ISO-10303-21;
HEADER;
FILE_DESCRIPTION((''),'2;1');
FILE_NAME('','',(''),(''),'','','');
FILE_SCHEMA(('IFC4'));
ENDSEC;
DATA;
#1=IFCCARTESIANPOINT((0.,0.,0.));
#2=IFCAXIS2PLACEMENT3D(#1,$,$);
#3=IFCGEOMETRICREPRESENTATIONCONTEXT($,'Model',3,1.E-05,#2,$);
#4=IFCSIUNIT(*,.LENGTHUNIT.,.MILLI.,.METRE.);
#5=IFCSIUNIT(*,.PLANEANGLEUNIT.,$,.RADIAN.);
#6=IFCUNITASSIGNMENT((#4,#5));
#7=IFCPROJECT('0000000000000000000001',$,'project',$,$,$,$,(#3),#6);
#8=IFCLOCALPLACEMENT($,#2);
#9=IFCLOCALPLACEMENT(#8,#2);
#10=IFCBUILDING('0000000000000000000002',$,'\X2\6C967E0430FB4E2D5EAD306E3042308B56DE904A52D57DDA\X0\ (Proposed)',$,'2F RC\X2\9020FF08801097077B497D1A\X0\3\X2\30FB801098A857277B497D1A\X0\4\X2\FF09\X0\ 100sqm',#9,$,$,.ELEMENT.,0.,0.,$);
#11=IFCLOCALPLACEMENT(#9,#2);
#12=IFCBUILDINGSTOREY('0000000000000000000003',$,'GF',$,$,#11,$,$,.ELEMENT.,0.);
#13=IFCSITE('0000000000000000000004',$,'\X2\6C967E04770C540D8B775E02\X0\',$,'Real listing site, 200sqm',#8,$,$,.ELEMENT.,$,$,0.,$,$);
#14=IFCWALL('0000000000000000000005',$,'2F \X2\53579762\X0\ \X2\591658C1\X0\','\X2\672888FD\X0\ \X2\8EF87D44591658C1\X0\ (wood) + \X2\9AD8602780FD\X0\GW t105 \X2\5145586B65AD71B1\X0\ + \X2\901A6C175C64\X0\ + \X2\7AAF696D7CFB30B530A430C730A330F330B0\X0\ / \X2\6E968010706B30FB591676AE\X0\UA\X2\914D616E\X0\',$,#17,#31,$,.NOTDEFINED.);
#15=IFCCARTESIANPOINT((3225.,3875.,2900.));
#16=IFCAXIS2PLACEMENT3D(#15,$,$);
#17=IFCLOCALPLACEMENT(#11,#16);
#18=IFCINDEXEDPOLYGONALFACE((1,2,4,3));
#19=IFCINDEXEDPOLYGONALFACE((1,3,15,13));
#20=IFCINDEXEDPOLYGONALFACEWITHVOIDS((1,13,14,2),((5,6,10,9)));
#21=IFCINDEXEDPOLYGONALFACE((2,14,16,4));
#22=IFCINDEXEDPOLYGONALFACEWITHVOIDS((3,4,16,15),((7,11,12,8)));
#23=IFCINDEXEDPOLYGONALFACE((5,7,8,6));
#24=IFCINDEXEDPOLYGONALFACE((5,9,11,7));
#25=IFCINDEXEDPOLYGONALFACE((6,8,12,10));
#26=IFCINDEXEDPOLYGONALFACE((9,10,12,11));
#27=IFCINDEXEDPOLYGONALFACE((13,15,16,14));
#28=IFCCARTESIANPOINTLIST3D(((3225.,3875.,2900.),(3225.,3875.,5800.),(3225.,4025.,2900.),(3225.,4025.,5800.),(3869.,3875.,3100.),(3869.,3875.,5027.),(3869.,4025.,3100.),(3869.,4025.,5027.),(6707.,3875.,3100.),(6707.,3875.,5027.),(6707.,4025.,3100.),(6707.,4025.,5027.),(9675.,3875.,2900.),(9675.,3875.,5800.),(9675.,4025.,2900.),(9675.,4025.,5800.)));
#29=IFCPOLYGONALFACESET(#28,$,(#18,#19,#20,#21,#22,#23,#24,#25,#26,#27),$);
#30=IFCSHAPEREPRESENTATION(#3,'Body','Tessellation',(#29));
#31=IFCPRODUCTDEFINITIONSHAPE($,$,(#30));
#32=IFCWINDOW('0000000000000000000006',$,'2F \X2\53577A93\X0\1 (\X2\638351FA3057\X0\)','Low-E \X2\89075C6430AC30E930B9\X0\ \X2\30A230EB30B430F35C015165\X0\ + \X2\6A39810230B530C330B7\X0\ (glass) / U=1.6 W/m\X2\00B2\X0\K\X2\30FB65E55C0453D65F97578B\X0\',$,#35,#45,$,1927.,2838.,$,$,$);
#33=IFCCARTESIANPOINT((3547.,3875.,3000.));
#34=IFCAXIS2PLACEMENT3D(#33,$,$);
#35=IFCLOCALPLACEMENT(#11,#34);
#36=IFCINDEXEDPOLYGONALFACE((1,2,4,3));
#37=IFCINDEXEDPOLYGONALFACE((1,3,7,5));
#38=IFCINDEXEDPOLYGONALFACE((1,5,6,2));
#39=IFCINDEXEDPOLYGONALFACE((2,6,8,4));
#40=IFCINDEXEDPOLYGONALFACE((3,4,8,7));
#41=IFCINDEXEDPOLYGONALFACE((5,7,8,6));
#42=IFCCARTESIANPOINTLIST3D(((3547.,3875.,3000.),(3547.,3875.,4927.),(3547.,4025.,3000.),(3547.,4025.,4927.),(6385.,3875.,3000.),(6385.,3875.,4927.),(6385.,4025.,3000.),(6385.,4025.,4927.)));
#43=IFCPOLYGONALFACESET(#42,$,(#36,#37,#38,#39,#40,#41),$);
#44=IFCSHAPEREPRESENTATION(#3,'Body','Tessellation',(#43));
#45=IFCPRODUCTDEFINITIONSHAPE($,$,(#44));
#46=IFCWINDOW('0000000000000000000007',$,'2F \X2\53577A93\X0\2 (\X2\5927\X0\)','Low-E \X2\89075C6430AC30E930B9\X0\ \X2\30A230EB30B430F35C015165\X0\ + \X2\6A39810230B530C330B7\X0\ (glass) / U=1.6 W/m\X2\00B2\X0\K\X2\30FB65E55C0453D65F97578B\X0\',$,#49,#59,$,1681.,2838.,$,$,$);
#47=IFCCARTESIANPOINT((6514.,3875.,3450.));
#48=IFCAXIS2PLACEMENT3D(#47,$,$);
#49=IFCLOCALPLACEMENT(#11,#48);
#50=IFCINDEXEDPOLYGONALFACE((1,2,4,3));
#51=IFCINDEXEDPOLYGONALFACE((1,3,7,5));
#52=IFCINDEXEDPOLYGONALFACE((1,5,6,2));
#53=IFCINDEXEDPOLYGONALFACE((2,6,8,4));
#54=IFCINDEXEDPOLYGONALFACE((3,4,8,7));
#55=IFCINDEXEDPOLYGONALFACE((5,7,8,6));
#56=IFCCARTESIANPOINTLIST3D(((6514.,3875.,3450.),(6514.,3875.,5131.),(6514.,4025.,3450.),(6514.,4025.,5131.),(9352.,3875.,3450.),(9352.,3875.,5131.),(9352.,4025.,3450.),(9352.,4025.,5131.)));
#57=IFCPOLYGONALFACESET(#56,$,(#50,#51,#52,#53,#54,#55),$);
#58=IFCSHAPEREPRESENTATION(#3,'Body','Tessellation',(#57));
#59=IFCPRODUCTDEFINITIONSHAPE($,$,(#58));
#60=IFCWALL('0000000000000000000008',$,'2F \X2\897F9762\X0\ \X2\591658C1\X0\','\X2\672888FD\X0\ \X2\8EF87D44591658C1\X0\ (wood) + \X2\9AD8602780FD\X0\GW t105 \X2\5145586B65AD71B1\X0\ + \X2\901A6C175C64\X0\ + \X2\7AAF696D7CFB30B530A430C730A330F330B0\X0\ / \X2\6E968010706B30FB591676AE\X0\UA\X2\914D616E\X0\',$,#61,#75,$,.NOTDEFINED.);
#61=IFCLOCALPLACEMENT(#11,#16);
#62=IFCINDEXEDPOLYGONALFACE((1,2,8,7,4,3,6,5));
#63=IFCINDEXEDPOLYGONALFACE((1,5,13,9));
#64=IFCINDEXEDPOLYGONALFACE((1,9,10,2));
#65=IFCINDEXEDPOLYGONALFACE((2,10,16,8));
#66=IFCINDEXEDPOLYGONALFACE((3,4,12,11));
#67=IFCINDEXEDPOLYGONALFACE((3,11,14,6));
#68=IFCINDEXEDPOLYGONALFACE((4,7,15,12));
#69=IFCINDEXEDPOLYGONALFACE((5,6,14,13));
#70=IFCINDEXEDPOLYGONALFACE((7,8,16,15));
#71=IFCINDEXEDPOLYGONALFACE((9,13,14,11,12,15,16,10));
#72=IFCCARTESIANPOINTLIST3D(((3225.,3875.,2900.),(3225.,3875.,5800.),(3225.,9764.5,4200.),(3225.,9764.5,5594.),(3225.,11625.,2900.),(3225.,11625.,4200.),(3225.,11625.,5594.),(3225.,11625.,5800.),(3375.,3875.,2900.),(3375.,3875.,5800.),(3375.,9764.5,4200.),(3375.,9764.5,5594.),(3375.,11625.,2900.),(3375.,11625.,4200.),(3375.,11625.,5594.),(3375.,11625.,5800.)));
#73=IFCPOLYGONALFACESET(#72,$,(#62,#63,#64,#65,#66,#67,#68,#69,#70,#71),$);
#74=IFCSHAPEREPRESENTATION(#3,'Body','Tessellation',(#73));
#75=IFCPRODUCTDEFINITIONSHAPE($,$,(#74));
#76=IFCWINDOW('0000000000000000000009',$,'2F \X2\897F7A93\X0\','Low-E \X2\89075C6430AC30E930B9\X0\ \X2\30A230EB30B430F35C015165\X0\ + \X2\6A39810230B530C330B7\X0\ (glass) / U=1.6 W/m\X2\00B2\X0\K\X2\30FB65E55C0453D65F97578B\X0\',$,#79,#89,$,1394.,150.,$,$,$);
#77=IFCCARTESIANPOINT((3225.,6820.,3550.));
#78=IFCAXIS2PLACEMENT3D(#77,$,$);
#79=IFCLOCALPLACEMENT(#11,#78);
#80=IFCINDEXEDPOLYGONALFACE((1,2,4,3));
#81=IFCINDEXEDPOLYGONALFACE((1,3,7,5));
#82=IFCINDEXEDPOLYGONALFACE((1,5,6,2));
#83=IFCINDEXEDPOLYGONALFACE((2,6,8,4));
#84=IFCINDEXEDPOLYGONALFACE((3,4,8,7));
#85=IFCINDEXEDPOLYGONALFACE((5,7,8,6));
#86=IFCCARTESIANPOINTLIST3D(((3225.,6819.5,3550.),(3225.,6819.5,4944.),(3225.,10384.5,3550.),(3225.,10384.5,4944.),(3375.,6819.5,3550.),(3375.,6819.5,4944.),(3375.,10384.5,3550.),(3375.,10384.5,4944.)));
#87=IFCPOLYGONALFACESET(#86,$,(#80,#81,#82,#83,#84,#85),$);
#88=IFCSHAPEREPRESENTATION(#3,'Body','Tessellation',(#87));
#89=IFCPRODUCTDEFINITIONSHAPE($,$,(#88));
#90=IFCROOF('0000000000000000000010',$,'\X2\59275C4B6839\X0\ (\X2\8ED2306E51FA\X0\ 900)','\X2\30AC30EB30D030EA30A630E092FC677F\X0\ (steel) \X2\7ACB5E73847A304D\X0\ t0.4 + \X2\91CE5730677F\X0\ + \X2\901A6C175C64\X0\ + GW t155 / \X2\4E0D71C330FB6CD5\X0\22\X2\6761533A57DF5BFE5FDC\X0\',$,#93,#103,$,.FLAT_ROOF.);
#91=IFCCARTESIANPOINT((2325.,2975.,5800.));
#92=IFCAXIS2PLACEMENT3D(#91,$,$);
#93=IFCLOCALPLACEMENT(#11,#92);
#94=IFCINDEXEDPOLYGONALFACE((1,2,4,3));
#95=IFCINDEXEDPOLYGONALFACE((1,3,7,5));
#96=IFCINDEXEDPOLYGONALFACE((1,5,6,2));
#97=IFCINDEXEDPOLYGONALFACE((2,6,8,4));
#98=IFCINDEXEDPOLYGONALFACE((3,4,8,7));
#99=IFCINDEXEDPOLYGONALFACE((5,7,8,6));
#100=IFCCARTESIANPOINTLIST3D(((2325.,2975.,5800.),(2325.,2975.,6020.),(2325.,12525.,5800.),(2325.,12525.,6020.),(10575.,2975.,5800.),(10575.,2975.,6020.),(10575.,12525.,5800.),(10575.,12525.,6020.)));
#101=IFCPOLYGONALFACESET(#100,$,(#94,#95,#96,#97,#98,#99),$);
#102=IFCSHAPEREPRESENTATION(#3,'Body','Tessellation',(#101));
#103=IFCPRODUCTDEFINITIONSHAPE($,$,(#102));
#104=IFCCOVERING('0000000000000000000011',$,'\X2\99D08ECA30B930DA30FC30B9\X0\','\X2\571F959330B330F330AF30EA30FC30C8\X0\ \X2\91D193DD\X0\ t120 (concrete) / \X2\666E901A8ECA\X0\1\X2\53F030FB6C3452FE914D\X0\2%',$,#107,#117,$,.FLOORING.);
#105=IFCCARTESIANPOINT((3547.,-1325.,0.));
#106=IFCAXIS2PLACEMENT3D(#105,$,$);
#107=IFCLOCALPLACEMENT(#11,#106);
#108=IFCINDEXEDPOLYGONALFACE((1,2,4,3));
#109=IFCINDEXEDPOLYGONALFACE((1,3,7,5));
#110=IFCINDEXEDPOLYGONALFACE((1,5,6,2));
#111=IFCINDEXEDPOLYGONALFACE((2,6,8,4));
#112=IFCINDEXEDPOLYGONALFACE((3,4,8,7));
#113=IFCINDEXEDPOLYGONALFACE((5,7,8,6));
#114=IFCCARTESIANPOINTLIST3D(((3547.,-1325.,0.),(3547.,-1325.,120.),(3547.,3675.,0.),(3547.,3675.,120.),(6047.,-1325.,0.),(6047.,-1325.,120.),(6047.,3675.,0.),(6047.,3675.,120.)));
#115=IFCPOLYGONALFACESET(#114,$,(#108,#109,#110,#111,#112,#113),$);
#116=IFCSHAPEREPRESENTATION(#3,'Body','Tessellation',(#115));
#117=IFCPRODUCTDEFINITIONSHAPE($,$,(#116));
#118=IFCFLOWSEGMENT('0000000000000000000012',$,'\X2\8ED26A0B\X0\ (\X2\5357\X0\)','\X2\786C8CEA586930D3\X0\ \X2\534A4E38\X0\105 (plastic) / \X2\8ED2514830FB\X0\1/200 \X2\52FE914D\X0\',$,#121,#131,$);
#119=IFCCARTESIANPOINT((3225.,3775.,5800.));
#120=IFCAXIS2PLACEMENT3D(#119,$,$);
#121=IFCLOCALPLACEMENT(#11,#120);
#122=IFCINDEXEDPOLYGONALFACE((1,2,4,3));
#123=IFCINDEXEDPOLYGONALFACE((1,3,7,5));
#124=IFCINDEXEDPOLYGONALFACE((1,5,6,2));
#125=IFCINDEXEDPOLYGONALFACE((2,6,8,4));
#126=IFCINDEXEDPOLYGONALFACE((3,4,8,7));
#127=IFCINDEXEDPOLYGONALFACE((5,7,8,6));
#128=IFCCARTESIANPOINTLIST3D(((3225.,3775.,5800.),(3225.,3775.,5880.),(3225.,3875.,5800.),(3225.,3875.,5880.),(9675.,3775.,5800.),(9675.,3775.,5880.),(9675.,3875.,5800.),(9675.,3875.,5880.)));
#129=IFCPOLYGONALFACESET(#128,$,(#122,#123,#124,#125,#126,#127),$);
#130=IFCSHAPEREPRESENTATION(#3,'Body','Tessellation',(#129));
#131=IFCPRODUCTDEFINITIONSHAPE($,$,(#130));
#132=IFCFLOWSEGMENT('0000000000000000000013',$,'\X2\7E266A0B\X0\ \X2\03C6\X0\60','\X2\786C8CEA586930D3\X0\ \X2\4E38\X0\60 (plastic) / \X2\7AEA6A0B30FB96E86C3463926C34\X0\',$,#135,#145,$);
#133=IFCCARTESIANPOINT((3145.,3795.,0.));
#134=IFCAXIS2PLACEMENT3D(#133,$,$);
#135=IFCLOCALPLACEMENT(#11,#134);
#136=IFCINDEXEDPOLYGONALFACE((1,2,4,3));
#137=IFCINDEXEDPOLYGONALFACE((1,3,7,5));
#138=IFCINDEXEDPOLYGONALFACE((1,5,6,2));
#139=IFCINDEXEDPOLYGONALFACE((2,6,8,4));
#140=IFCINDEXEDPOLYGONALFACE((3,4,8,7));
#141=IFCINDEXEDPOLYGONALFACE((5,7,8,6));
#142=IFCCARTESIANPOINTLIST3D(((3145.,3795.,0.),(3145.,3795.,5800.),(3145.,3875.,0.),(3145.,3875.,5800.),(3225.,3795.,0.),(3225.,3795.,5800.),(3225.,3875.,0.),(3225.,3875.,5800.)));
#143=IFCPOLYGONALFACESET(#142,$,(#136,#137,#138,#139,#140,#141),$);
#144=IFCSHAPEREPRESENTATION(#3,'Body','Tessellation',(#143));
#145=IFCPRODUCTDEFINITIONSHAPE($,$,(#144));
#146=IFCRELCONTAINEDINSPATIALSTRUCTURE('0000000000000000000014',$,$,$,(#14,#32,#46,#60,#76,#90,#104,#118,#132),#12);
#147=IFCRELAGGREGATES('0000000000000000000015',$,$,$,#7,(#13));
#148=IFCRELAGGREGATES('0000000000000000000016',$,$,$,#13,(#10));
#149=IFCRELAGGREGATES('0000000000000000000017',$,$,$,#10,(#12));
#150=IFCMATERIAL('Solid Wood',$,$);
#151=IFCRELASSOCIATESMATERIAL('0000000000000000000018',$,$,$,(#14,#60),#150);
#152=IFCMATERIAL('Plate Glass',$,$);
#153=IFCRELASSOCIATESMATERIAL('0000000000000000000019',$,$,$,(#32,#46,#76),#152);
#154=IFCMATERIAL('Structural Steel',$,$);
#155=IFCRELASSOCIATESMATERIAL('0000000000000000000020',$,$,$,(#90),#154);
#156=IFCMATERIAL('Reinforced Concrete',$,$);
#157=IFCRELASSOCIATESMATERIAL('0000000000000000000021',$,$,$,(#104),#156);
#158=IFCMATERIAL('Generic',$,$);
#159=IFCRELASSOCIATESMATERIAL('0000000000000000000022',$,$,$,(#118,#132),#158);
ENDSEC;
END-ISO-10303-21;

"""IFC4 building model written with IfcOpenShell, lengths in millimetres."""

from ifc_helpers import new_model, si_unit, frame, frame_2d, origin, place, context, project, spatial, rectangle, extrude, material, element, fill, save


model = new_model("IFC4")

# Units and contexts
model_context = context("Model", 3, precision=1e-05, world=origin())
ifc_project = project(units=[si_unit("LENGTHUNIT", "METRE", prefix="MILLI"), si_unit("PLANEANGLEUNIT", "RADIAN")], contexts=[model_context])

# Site, building, storey
site_placement = place(None, origin())
site = spatial("IfcSite", under=ifc_project, at=site_placement, Name="沖縄県名護市", ObjectType="Real listing site, 200sqm", CompositionType="ELEMENT", RefElevation=0.0)
building_placement = place(site_placement, origin())
building = spatial("IfcBuilding", under=site, at=building_placement, Name="沖縄・中庭のある回遊動線 (Proposed)", ObjectType="2F RC造（耐震等級3・耐風圧等級4） 100sqm", CompositionType="ELEMENT", ElevationOfRefHeight=0.0, ElevationOfTerrain=0.0)
storey_placement = place(building_placement, origin())
storey = spatial("IfcBuildingStorey", under=building, at=storey_placement, Name="GF", CompositionType="ELEMENT", Elevation=0.0)

# Shared definitions
ifc_material_1 = material(Name="Solid Wood")

# Shared definitions
ifc_material_2 = material(Name="Reinforced Concrete")

# Shared definitions
ifc_material_3 = material(Name="Plate Glass")

# Wall, openings, windows
wall_1_placement = place(storey_placement, frame((3225.0, 3875.0, 2900.0)))
wall_1 = element("IfcWall", 1, at=wall_1_placement, inside=storey, material=ifc_material_1, Name="2F 南面 外壁", Description="木製 軸組外壁 (wood) + 高性能GW t105 充填断熱 + 通気層 + 窯業系サイディング / 準耐火・外皮UA配慮", PredefinedType="NOTDEFINED", context=model_context, shape_type="SweptSolid", body=[
    extrude(rectangle(XDim=6450.0, YDim=150.0, at=frame_2d((3225.0, 75.0))), frame((3225.0, 3875.0, 2900.0)), (0.0, 0.0, 1.0), 2900.0),
])
opening_1_placement = place(storey_placement, frame((3547.0, 3875.0, 3000.0)))
opening_1 = element("IfcOpeningElement", 2, at=opening_1_placement, cuts=wall_1, PredefinedType="NOTDEFINED", context=model_context, shape_type="SweptSolid", body=[
    extrude(rectangle(XDim=2838.0, YDim=150.0, at=frame_2d((1419.0, 75.0))), frame((3547.0, 3875.0, 3000.0)), (0.0, 0.0, 1.0), 1927.0),
])
opening_2_placement = place(storey_placement, frame((6514.0, 3875.0, 3450.0)))
opening_2 = element("IfcOpeningElement", 3, at=opening_2_placement, cuts=wall_1, PredefinedType="NOTDEFINED", context=model_context, shape_type="SweptSolid", body=[
    extrude(rectangle(XDim=2838.0, YDim=150.0, at=frame_2d((1419.0, 75.0))), frame((6514.0, 3875.0, 3450.0)), (0.0, 0.0, 1.0), 1681.0),
])
window_1_placement = place(storey_placement, frame((3547.0, 3875.0, 3000.0)))
window_1 = element("IfcWindow", 4, at=window_1_placement, inside=storey, material=ifc_material_3, Name="2F 南窓1 (掃出し)", Description="Low-E 複層ガラス アルゴン封入 + 樹脂サッシ (glass) / U=1.6 W/m²K・日射取得型", OverallHeight=1927.0, OverallWidth=2838.0, context=model_context, shape_type="SweptSolid", body=[
    extrude(rectangle(XDim=2838.0, YDim=150.0, at=frame_2d((1419.0, 75.0))), frame((3547.0, 3875.0, 3000.0)), (0.0, 0.0, 1.0), 1927.0),
])
fill(opening_1, window_1)
window_2_placement = place(storey_placement, frame((6514.0, 3875.0, 3450.0)))
window_2 = element("IfcWindow", 5, at=window_2_placement, inside=storey, material=ifc_material_3, Name="2F 南窓2 (大)", Description="Low-E 複層ガラス アルゴン封入 + 樹脂サッシ (glass) / U=1.6 W/m²K・日射取得型", OverallHeight=1681.0, OverallWidth=2838.0, context=model_context, shape_type="SweptSolid", body=[
    extrude(rectangle(XDim=2838.0, YDim=150.0, at=frame_2d((1419.0, 75.0))), frame((6514.0, 3875.0, 3450.0)), (0.0, 0.0, 1.0), 1681.0),
])
fill(opening_2, window_2)

# Wall, opening, window
wall_2_placement = place(storey_placement, frame((3225.0, 3875.0, 2900.0)))
wall_2 = element("IfcWall", 6, at=wall_2_placement, inside=storey, material=ifc_material_1, Name="2F 西面 外壁", Description="木製 軸組外壁 (wood) + 高性能GW t105 充填断熱 + 通気層 + 窯業系サイディング / 準耐火・外皮UA配慮", PredefinedType="NOTDEFINED", context=model_context, shape_type="SweptSolid", body=[
    extrude(rectangle(XDim=150.0, YDim=7750.0, at=frame_2d((75.0, 3875.0))), frame((3225.0, 3875.0, 2900.0)), (0.0, 0.0, 1.0), 2900.0),
])
opening_3_placement = place(storey_placement, frame((3225.0, 6820.0, 3550.0)))
opening_3 = element("IfcOpeningElement", 7, at=opening_3_placement, cuts=wall_2, PredefinedType="NOTDEFINED", context=model_context, shape_type="SweptSolid", body=[
    extrude(rectangle(XDim=150.0, YDim=3565.0, at=frame_2d((75.0, 1782.0))), frame((3225.0, 6820.0, 3550.0)), (0.0, 0.0, 1.0), 1394.0),
])
window_3_placement = place(storey_placement, frame((3225.0, 6820.0, 3550.0)))
window_3 = element("IfcWindow", 8, at=window_3_placement, inside=storey, material=ifc_material_3, Name="2F 西窓", Description="Low-E 複層ガラス アルゴン封入 + 樹脂サッシ (glass) / U=1.6 W/m²K・日射取得型", OverallHeight=1394.0, OverallWidth=150.0, context=model_context, shape_type="SweptSolid", body=[
    extrude(rectangle(XDim=150.0, YDim=3565.0, at=frame_2d((75.0, 1782.0))), frame((3225.0, 6820.0, 3550.0)), (0.0, 0.0, 1.0), 1394.0),
])
fill(opening_3, window_3)

# Roof
ifc_material_4 = material(Name="Structural Steel")
roof_placement = place(storey_placement, frame((2325.0, 2975.0, 5800.0)))
element("IfcRoof", 9, at=roof_placement, inside=storey, material=ifc_material_4, Name="大屋根 (軒の出 900)", Description="ガルバリウム鋼板 (steel) 立平葺き t0.4 + 野地板 + 通気層 + GW t155 / 不燃・法22条区域対応", PredefinedType="FLAT_ROOF", context=model_context, shape_type="SweptSolid", body=[
    extrude(rectangle(XDim=8250.0, YDim=9550.0, at=frame_2d((4125.0, 4775.0))), frame((2325.0, 2975.0, 5800.0)), (0.0, 0.0, 1.0), 220.0),
])

# Covering
covering_placement = place(storey_placement, frame((3547.0, -1325.0, 0.0)))
element("IfcCovering", 10, at=covering_placement, inside=storey, material=ifc_material_2, Name="駐車スペース", Description="土間コンクリート 金鏝 t120 (concrete) / 普通車1台・水勾配2%", PredefinedType="FLOORING", context=model_context, shape_type="SweptSolid", body=[
    extrude(rectangle(XDim=2500.0, YDim=5000.0, at=frame_2d((1250.0, 2500.0))), frame((3547.0, -1325.0, 0.0)), (0.0, 0.0, 1.0), 120.0),
])

# Flow segments
ifc_material_5 = material(Name="Generic")
flow_segment_1_placement = place(storey_placement, frame((3225.0, 3775.0, 5800.0)))
element("IfcFlowSegment", 11, at=flow_segment_1_placement, inside=storey, material=ifc_material_5, Name="軒樋 (南)", Description="硬質塩ビ 半丸105 (plastic) / 軒先・1/200 勾配", context=model_context, shape_type="SweptSolid", body=[
    extrude(rectangle(XDim=6450.0, YDim=100.0, at=frame_2d((3225.0, 50.0))), frame((3225.0, 3775.0, 5800.0)), (0.0, 0.0, 1.0), 80.0),
])
flow_segment_2_placement = place(storey_placement, frame((3145.0, 3795.0, 0.0)))
element("IfcFlowSegment", 12, at=flow_segment_2_placement, inside=storey, material=ifc_material_5, Name="縦樋 φ60", Description="硬質塩ビ 丸60 (plastic) / 竪樋・雨水排水", context=model_context, shape_type="SweptSolid", body=[
    extrude(rectangle(XDim=80.0, YDim=80.0, at=frame_2d((40.0, 40.0))), frame((3145.0, 3795.0, 0.0)), (0.0, 0.0, 1.0), 5800.0),
])

save(model, "model.ifc")
